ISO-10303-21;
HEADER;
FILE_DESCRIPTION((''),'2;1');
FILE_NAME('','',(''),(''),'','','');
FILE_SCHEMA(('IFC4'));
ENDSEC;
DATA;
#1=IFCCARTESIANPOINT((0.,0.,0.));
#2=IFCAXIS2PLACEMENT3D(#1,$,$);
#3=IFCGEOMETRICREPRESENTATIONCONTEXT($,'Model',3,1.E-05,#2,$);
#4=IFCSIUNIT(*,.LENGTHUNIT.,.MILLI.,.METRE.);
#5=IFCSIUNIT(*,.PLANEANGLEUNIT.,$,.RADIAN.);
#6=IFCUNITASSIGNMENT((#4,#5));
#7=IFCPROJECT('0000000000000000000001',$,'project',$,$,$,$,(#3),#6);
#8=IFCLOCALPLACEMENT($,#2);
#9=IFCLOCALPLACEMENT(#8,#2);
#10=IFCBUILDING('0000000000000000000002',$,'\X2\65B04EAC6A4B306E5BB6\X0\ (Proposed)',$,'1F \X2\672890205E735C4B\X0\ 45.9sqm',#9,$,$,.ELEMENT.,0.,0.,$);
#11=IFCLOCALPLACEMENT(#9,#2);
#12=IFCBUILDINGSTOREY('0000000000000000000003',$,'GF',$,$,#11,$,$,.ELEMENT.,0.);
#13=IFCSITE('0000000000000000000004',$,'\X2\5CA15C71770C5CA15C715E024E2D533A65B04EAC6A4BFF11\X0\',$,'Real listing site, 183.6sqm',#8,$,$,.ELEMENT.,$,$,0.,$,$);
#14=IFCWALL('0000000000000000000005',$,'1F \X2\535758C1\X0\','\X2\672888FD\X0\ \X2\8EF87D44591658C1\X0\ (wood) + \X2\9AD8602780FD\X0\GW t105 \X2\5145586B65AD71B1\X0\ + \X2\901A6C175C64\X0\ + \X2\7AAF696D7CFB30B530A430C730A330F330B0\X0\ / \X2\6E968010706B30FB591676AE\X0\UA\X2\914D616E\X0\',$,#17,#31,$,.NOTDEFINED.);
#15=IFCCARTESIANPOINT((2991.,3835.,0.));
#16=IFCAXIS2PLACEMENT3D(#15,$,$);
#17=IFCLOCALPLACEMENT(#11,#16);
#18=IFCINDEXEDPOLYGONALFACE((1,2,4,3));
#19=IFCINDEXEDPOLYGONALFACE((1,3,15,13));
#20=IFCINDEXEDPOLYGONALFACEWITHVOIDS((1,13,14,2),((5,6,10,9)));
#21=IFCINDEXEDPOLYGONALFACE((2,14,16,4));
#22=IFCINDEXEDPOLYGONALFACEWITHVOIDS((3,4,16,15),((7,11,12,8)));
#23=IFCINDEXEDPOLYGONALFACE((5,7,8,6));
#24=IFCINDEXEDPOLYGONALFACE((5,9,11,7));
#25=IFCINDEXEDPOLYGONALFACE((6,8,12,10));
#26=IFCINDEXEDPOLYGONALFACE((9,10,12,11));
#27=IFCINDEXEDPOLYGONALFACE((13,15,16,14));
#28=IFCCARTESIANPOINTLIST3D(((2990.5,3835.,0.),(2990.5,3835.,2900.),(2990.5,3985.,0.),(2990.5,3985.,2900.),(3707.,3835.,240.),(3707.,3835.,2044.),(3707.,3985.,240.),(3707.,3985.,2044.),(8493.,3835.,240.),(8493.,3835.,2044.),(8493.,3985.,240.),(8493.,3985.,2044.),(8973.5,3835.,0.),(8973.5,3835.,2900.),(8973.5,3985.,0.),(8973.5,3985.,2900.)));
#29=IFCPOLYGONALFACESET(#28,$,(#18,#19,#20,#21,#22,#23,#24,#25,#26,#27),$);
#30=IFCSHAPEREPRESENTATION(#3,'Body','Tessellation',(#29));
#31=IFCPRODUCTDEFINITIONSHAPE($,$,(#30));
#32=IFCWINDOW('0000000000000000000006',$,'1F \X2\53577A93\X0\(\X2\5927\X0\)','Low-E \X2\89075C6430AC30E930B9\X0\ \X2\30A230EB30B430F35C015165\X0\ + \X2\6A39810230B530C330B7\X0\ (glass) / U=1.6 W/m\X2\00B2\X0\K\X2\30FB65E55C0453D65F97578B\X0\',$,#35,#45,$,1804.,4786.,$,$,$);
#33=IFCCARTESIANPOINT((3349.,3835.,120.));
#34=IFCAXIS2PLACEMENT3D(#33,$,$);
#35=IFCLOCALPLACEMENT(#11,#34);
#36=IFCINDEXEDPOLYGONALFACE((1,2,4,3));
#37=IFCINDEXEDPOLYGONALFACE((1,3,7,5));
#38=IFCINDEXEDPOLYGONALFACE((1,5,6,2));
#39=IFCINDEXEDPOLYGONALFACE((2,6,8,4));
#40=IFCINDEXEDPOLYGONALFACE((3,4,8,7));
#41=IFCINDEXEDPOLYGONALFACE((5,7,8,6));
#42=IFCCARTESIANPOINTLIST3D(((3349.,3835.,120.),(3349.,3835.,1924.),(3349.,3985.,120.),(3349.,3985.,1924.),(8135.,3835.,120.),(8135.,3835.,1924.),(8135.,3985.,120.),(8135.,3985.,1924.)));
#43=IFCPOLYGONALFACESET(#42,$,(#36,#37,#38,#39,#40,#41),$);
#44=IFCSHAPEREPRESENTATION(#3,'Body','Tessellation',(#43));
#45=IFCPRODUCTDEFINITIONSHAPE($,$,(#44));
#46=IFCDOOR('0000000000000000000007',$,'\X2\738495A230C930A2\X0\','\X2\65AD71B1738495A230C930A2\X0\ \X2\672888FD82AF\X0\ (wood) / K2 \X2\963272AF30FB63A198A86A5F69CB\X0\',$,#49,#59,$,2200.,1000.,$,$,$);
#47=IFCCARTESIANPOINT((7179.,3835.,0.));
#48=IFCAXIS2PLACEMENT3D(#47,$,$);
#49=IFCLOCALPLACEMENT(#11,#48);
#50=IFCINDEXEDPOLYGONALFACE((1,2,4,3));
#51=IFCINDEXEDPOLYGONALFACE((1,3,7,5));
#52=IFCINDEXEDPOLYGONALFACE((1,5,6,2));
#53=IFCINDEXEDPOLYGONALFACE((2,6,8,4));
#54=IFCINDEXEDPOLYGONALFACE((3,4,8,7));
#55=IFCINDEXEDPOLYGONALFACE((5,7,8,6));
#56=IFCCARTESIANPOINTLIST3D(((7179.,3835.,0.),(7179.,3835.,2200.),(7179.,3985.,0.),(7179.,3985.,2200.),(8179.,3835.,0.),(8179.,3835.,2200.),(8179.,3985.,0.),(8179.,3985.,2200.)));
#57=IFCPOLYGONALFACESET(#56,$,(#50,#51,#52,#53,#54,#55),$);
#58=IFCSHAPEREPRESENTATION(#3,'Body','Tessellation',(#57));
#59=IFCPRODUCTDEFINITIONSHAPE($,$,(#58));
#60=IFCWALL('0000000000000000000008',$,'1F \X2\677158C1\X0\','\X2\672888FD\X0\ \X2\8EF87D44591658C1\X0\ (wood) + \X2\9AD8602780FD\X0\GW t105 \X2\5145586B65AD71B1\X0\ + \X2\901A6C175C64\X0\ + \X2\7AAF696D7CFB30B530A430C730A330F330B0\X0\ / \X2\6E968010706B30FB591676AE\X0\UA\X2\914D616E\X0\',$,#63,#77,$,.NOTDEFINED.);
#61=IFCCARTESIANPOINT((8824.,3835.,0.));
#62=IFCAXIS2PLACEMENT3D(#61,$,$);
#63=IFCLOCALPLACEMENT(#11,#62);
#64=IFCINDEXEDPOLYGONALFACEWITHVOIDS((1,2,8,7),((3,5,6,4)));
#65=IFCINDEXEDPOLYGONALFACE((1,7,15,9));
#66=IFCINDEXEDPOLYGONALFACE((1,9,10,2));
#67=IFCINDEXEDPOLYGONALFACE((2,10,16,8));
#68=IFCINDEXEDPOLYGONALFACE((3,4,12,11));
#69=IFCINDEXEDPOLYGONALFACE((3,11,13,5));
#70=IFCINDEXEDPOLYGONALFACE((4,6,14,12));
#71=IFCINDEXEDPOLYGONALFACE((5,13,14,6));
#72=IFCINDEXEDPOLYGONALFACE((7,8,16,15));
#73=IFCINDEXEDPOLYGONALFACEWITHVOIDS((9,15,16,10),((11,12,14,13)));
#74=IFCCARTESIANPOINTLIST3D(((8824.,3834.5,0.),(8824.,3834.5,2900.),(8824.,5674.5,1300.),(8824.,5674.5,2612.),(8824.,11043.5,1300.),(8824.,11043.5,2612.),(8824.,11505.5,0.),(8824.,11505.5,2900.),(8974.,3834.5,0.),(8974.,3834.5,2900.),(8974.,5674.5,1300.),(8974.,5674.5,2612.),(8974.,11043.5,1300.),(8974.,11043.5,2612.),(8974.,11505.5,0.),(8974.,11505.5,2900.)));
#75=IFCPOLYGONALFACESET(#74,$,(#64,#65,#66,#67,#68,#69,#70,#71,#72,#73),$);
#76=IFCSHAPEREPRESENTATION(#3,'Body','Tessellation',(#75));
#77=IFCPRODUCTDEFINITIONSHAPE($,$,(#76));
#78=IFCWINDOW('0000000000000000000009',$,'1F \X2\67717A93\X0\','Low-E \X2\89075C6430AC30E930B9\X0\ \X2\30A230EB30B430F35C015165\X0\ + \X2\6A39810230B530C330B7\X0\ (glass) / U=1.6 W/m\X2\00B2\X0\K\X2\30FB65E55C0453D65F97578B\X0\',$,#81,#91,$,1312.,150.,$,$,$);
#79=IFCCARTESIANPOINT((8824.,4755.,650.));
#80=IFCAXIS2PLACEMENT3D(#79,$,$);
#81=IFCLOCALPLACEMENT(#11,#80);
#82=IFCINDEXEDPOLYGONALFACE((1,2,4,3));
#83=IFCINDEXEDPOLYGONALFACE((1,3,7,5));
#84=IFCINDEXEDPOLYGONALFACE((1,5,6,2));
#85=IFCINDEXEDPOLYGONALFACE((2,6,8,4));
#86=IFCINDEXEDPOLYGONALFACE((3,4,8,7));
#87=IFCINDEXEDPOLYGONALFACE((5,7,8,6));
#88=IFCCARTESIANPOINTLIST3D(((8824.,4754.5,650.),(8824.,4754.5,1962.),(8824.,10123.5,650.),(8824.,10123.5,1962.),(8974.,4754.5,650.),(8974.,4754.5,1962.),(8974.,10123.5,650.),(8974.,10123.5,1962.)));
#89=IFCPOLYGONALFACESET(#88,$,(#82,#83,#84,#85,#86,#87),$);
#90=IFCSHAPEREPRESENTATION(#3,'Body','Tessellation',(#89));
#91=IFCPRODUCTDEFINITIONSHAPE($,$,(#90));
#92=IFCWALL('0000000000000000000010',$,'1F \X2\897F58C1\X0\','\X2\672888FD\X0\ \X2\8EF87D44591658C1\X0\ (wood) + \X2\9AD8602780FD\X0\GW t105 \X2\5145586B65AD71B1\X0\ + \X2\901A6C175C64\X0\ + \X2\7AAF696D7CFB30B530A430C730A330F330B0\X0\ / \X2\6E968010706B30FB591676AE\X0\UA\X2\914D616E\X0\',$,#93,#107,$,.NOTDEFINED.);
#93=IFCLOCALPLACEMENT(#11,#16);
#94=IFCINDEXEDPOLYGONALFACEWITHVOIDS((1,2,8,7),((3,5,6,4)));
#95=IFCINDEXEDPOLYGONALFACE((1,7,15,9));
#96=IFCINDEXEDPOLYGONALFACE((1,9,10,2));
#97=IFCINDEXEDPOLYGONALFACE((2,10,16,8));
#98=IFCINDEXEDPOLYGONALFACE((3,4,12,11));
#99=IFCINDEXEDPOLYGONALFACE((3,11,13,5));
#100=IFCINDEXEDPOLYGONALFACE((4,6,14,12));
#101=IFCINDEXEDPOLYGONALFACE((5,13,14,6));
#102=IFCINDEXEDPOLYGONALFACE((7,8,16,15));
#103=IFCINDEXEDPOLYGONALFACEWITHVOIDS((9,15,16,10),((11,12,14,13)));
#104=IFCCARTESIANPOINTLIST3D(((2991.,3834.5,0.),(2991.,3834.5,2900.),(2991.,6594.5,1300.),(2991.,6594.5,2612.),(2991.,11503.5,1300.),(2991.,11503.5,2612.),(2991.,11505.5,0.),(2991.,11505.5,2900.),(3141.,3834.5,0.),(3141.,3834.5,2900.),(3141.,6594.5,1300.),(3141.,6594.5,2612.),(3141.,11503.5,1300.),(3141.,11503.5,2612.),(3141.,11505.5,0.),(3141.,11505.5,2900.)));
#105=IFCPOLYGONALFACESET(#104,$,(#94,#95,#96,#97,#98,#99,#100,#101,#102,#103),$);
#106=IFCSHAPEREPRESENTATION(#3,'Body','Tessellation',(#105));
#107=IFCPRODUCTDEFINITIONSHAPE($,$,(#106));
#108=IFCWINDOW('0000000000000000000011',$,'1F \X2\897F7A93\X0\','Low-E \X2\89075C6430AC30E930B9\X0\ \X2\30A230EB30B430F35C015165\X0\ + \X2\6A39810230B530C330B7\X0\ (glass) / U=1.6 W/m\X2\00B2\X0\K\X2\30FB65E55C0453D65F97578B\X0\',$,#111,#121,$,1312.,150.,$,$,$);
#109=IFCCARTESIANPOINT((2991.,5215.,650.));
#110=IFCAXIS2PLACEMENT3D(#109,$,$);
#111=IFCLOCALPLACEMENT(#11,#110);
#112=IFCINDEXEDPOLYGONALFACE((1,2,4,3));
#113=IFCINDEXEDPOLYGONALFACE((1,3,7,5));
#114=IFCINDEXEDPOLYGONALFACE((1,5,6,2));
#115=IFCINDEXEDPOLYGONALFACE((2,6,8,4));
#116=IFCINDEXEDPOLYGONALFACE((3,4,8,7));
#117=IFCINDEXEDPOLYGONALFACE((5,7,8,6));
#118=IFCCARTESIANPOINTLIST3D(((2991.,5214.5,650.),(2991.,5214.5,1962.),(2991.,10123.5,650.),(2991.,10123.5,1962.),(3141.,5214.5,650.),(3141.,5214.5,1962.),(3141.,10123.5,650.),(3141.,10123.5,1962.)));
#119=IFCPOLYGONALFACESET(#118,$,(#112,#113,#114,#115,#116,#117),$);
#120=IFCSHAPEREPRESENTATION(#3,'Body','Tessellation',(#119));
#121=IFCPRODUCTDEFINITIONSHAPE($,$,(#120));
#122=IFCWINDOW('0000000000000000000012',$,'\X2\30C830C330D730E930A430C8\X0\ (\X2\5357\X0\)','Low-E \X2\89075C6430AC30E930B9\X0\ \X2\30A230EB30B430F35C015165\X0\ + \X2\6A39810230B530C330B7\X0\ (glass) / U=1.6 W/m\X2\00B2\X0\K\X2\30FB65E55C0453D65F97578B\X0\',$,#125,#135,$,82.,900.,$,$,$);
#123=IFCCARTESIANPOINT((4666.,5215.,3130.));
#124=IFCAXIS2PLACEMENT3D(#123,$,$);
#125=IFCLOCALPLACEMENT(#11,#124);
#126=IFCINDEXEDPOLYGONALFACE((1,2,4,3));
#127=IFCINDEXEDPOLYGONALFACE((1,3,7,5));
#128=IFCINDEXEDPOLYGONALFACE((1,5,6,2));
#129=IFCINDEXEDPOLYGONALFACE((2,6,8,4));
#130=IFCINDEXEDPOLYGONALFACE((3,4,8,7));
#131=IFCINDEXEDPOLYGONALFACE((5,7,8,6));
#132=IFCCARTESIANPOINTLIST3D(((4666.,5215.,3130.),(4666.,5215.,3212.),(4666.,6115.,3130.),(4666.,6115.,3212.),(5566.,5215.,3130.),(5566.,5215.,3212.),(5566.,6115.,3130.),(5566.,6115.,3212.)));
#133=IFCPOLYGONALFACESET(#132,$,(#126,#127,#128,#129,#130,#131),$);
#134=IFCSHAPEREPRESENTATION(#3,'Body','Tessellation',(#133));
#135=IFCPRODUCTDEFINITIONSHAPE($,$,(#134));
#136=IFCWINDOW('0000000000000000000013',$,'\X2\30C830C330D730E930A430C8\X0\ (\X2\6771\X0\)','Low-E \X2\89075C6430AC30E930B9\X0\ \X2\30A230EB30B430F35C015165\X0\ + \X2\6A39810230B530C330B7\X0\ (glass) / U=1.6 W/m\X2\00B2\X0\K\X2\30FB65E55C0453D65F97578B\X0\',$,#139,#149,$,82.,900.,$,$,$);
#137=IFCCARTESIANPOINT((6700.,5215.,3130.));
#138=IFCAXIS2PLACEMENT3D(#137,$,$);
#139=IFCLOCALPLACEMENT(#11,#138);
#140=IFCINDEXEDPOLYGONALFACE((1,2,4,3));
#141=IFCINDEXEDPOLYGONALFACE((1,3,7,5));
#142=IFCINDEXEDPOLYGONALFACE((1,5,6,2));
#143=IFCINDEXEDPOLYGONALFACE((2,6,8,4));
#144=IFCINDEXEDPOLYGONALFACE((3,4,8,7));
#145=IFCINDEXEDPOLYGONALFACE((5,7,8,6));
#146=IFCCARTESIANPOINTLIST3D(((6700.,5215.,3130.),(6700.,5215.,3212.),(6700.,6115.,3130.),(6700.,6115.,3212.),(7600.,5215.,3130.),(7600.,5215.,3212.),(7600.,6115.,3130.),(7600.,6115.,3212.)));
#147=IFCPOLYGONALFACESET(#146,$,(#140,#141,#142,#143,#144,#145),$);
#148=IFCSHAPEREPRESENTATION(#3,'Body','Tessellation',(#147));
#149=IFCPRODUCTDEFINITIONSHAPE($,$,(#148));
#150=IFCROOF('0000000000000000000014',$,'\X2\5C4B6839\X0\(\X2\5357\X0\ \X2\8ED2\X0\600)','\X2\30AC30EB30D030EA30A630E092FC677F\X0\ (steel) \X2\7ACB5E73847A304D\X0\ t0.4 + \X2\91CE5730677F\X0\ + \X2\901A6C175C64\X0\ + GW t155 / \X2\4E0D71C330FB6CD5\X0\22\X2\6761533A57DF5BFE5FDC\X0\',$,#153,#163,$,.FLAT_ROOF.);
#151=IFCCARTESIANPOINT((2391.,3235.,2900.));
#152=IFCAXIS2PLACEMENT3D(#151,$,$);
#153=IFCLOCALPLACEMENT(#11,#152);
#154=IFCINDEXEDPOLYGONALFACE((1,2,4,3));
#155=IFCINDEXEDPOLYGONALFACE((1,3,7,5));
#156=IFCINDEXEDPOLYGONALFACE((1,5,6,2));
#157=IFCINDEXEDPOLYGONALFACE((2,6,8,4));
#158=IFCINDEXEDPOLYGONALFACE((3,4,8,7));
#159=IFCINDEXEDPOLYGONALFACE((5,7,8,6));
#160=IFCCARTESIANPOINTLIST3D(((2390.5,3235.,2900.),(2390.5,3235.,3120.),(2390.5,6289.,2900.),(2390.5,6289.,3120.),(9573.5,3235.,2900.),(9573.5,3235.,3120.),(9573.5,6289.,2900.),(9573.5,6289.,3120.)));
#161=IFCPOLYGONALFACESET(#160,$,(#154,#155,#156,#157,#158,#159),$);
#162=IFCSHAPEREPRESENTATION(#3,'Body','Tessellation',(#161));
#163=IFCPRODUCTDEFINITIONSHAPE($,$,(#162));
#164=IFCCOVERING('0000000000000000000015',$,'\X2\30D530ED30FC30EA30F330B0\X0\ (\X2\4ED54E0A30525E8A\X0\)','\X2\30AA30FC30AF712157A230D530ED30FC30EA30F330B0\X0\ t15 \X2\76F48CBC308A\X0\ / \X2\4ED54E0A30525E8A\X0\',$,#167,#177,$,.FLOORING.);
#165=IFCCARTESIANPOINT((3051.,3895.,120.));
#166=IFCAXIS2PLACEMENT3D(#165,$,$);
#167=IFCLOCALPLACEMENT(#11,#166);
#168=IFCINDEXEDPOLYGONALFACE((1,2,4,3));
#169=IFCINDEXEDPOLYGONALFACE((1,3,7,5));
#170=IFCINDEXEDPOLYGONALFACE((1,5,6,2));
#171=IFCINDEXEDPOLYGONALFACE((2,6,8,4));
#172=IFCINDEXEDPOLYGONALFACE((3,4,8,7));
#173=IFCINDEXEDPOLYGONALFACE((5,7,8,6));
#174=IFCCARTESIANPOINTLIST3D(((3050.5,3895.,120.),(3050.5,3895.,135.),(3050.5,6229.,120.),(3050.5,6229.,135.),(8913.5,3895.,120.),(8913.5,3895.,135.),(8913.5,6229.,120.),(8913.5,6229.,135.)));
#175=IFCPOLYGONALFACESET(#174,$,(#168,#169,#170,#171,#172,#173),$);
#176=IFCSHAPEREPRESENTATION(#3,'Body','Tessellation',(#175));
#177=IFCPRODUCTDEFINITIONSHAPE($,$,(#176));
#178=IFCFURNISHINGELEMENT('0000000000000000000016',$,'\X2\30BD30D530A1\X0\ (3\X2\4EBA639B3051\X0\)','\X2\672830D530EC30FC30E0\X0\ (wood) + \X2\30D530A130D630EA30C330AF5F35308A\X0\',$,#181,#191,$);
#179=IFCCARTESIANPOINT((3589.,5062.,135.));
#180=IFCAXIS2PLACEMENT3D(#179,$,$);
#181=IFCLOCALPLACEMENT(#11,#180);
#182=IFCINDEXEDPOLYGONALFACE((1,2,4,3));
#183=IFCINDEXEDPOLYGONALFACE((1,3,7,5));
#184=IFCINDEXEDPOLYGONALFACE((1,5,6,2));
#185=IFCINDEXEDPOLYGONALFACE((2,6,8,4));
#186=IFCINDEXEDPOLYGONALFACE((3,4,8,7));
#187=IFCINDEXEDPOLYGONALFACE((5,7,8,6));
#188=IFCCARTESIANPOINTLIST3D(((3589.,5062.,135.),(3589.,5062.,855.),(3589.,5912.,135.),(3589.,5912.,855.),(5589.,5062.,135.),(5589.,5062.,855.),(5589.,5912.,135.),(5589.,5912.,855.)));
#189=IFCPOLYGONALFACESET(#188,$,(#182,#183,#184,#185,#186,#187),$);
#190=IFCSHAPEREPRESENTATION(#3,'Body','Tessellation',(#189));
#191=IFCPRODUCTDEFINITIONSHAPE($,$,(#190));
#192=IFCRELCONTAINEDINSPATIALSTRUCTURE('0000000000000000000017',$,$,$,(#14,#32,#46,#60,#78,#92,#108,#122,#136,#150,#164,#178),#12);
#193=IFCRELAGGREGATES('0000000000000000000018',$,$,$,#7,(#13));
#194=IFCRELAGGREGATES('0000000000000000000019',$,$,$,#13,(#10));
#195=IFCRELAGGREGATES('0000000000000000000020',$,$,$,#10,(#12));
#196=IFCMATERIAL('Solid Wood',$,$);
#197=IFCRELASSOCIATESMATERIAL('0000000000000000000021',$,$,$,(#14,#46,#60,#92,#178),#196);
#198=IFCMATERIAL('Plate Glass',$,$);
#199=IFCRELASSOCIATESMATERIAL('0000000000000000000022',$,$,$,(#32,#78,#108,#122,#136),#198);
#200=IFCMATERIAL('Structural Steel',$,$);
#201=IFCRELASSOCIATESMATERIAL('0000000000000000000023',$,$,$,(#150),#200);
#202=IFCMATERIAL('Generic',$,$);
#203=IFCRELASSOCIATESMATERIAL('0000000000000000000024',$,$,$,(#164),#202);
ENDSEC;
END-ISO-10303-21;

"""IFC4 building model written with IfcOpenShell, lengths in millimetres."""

from ifc_helpers import new_model, si_unit, frame, frame_2d, origin, place, context, project, spatial, rectangle, extrude, material, element, fill, save


model = new_model("IFC4")

# Units and contexts
model_context = context("Model", 3, precision=1e-05, world=origin())
ifc_project = project(units=[si_unit("LENGTHUNIT", "METRE", prefix="MILLI"), si_unit("PLANEANGLEUNIT", "RADIAN")], contexts=[model_context])

# Site, building, storey
site_placement = place(None, origin())
site = spatial("IfcSite", under=ifc_project, at=site_placement, Name="岡山県岡山市中区新京橋１", ObjectType="Real listing site, 183.6sqm", CompositionType="ELEMENT", RefElevation=0.0)
building_placement = place(site_placement, origin())
building = spatial("IfcBuilding", under=site, at=building_placement, Name="新京橋の家 (Proposed)", ObjectType="1F 木造平屋 45.9sqm", CompositionType="ELEMENT", ElevationOfRefHeight=0.0, ElevationOfTerrain=0.0)
storey_placement = place(building_placement, origin())
storey = spatial("IfcBuildingStorey", under=building, at=storey_placement, Name="GF", CompositionType="ELEMENT", Elevation=0.0)

# Shared definitions
ifc_material_1 = material(Name="Solid Wood")

# Wall, openings, window, door
wall_1_placement = place(storey_placement, frame((2991.0, 3835.0, 0.0)))
wall_1 = element("IfcWall", 1, at=wall_1_placement, inside=storey, material=ifc_material_1, Name="1F 南壁", Description="木製 軸組外壁 (wood) + 高性能GW t105 充填断熱 + 通気層 + 窯業系サイディング / 準耐火・外皮UA配慮", PredefinedType="NOTDEFINED", context=model_context, shape_type="SweptSolid", body=[
    extrude(rectangle(XDim=5983.0, YDim=150.0, at=frame_2d((2991.0, 75.0))), frame((2991.0, 3835.0, 0.0)), (0.0, 0.0, 1.0), 2900.0),
])
opening_1_placement = place(storey_placement, frame((3349.0, 3835.0, 120.0)))
opening_1 = element("IfcOpeningElement", 2, at=opening_1_placement, cuts=wall_1, PredefinedType="NOTDEFINED", context=model_context, shape_type="SweptSolid", body=[
    extrude(rectangle(XDim=4786.0, YDim=150.0, at=frame_2d((2393.0, 75.0))), frame((3349.0, 3835.0, 120.0)), (0.0, 0.0, 1.0), 1804.0),
])
opening_2_placement = place(storey_placement, frame((7179.0, 3835.0, 0.0)))
opening_2 = element("IfcOpeningElement", 3, at=opening_2_placement, cuts=wall_1, PredefinedType="NOTDEFINED", context=model_context, shape_type="SweptSolid", body=[
    extrude(rectangle(XDim=1000.0, YDim=150.0, at=frame_2d((500.0, 75.0))), frame((7179.0, 3835.0, 0.0)), (0.0, 0.0, 1.0), 2200.0),
])
ifc_material_2 = material(Name="Plate Glass")
window_1_placement = place(storey_placement, frame((3349.0, 3835.0, 120.0)))
window_1 = element("IfcWindow", 4, at=window_1_placement, inside=storey, material=ifc_material_2, Name="1F 南窓(大)", Description="Low-E 複層ガラス アルゴン封入 + 樹脂サッシ (glass) / U=1.6 W/m²K・日射取得型", OverallHeight=1804.0, OverallWidth=4786.0, context=model_context, shape_type="SweptSolid", body=[
    extrude(rectangle(XDim=4786.0, YDim=150.0, at=frame_2d((2393.0, 75.0))), frame((3349.0, 3835.0, 120.0)), (0.0, 0.0, 1.0), 1804.0),
])
fill(opening_1, window_1)
door_placement = place(storey_placement, frame((7179.0, 3835.0, 0.0)))
door = element("IfcDoor", 5, at=door_placement, inside=storey, material=ifc_material_1, Name="玄関ドア", Description="断熱玄関ドア 木製芯 (wood) / K2 防犯・採風機構", OverallHeight=2200.0, OverallWidth=1000.0, context=model_context, shape_type="SweptSolid", body=[
    extrude(rectangle(XDim=1000.0, YDim=150.0, at=frame_2d((500.0, 75.0))), frame((7179.0, 3835.0, 0.0)), (0.0, 0.0, 1.0), 2200.0),
])
fill(opening_2, door)

# Walls, openings, windows
wall_2_placement = place(storey_placement, frame((8824.0, 3835.0, 0.0)))
wall_2 = element("IfcWall", 6, at=wall_2_placement, inside=storey, material=ifc_material_1, Name="1F 東壁", Description="木製 軸組外壁 (wood) + 高性能GW t105 充填断熱 + 通気層 + 窯業系サイディング / 準耐火・外皮UA配慮", PredefinedType="NOTDEFINED", context=model_context, shape_type="SweptSolid", body=[
    extrude(rectangle(XDim=150.0, YDim=7671.0, at=frame_2d((75.0, 3835.0))), frame((8824.0, 3835.0, 0.0)), (0.0, 0.0, 1.0), 2900.0),
])
opening_3_placement = place(storey_placement, frame((8824.0, 4755.0, 650.0)))
opening_3 = element("IfcOpeningElement", 7, at=opening_3_placement, cuts=wall_2, PredefinedType="NOTDEFINED", context=model_context, shape_type="SweptSolid", body=[
    extrude(rectangle(XDim=150.0, YDim=5369.0, at=frame_2d((75.0, 2684.0))), frame((8824.0, 4755.0, 650.0)), (0.0, 0.0, 1.0), 1312.0),
])
window_2_placement = place(storey_placement, frame((8824.0, 4755.0, 650.0)))
window_2 = element("IfcWindow", 8, at=window_2_placement, inside=storey, material=ifc_material_2, Name="1F 東窓", Description="Low-E 複層ガラス アルゴン封入 + 樹脂サッシ (glass) / U=1.6 W/m²K・日射取得型", OverallHeight=1312.0, OverallWidth=150.0, context=model_context, shape_type="SweptSolid", body=[
    extrude(rectangle(XDim=150.0, YDim=5369.0, at=frame_2d((75.0, 2684.0))), frame((8824.0, 4755.0, 650.0)), (0.0, 0.0, 1.0), 1312.0),
])
fill(opening_3, window_2)
wall_3_placement = place(storey_placement, frame((2991.0, 3835.0, 0.0)))
wall_3 = element("IfcWall", 9, at=wall_3_placement, inside=storey, material=ifc_material_1, Name="1F 西壁", Description="木製 軸組外壁 (wood) + 高性能GW t105 充填断熱 + 通気層 + 窯業系サイディング / 準耐火・外皮UA配慮", PredefinedType="NOTDEFINED", context=model_context, shape_type="SweptSolid", body=[
    extrude(rectangle(XDim=150.0, YDim=7671.0, at=frame_2d((75.0, 3835.0))), frame((2991.0, 3835.0, 0.0)), (0.0, 0.0, 1.0), 2900.0),
])
opening_4_placement = place(storey_placement, frame((2991.0, 5215.0, 650.0)))
opening_4 = element("IfcOpeningElement", 10, at=opening_4_placement, cuts=wall_3, PredefinedType="NOTDEFINED", context=model_context, shape_type="SweptSolid", body=[
    extrude(rectangle(XDim=150.0, YDim=4909.0, at=frame_2d((75.0, 2454.0))), frame((2991.0, 5215.0, 650.0)), (0.0, 0.0, 1.0), 1312.0),
])
window_3_placement = place(storey_placement, frame((2991.0, 5215.0, 650.0)))
window_3 = element("IfcWindow", 11, at=window_3_placement, inside=storey, material=ifc_material_2, Name="1F 西窓", Description="Low-E 複層ガラス アルゴン封入 + 樹脂サッシ (glass) / U=1.6 W/m²K・日射取得型", OverallHeight=1312.0, OverallWidth=150.0, context=model_context, shape_type="SweptSolid", body=[
    extrude(rectangle(XDim=150.0, YDim=4909.0, at=frame_2d((75.0, 2454.0))), frame((2991.0, 5215.0, 650.0)), (0.0, 0.0, 1.0), 1312.0),
])
fill(opening_4, window_3)

# Windows
window_4_placement = place(storey_placement, frame((4666.0, 5215.0, 3130.0)))
element("IfcWindow", 12, at=window_4_placement, inside=storey, material=ifc_material_2, Name="トップライト (南)", Description="Low-E 複層ガラス アルゴン封入 + 樹脂サッシ (glass) / U=1.6 W/m²K・日射取得型", OverallHeight=82.0, OverallWidth=900.0, context=model_context, shape_type="SweptSolid", body=[
    extrude(rectangle(XDim=900.0, YDim=900.0, at=frame_2d((450.0, 450.0))), frame((4666.0, 5215.0, 3130.0)), (0.0, 0.0, 1.0), 82.0),
])
window_5_placement = place(storey_placement, frame((6700.0, 5215.0, 3130.0)))
element("IfcWindow", 13, at=window_5_placement, inside=storey, material=ifc_material_2, Name="トップライト (東)", Description="Low-E 複層ガラス アルゴン封入 + 樹脂サッシ (glass) / U=1.6 W/m²K・日射取得型", OverallHeight=82.0, OverallWidth=900.0, context=model_context, shape_type="SweptSolid", body=[
    extrude(rectangle(XDim=900.0, YDim=900.0, at=frame_2d((450.0, 450.0))), frame((6700.0, 5215.0, 3130.0)), (0.0, 0.0, 1.0), 82.0),
])

# Roof
ifc_material_3 = material(Name="Structural Steel")
roof_placement = place(storey_placement, frame((2391.0, 3235.0, 2900.0)))
element("IfcRoof", 14, at=roof_placement, inside=storey, material=ifc_material_3, Name="屋根(南 軒600)", Description="ガルバリウム鋼板 (steel) 立平葺き t0.4 + 野地板 + 通気層 + GW t155 / 不燃・法22条区域対応", PredefinedType="FLAT_ROOF", context=model_context, shape_type="SweptSolid", body=[
    extrude(rectangle(XDim=7183.0, YDim=3054.0, at=frame_2d((3591.0, 1527.0))), frame((2391.0, 3235.0, 2900.0)), (0.0, 0.0, 1.0), 220.0),
])

# Covering
ifc_material_4 = material(Name="Generic")
covering_placement = place(storey_placement, frame((3051.0, 3895.0, 120.0)))
element("IfcCovering", 15, at=covering_placement, inside=storey, material=ifc_material_4, Name="フローリング (仕上げ床)", Description="オーク無垢フローリング t15 直貼り / 仕上げ床", PredefinedType="FLOORING", context=model_context, shape_type="SweptSolid", body=[
    extrude(rectangle(XDim=5863.0, YDim=2334.0, at=frame_2d((2931.0, 1167.0))), frame((3051.0, 3895.0, 120.0)), (0.0, 0.0, 1.0), 15.0),
])

# Furnishing element
furnishing_1_placement = place(storey_placement, frame((3589.0, 5062.0, 135.0)))
element("IfcFurnishingElement", 16, at=furnishing_1_placement, inside=storey, material=ifc_material_1, Name="ソファ (3人掛け)", Description="木フレーム (wood) + ファブリック張り", context=model_context, shape_type="SweptSolid", body=[
    extrude(rectangle(XDim=2000.0, YDim=850.0, at=frame_2d((1000.0, 425.0))), frame((3589.0, 5062.0, 135.0)), (0.0, 0.0, 1.0), 720.0),
])

save(model, "model.ifc")
